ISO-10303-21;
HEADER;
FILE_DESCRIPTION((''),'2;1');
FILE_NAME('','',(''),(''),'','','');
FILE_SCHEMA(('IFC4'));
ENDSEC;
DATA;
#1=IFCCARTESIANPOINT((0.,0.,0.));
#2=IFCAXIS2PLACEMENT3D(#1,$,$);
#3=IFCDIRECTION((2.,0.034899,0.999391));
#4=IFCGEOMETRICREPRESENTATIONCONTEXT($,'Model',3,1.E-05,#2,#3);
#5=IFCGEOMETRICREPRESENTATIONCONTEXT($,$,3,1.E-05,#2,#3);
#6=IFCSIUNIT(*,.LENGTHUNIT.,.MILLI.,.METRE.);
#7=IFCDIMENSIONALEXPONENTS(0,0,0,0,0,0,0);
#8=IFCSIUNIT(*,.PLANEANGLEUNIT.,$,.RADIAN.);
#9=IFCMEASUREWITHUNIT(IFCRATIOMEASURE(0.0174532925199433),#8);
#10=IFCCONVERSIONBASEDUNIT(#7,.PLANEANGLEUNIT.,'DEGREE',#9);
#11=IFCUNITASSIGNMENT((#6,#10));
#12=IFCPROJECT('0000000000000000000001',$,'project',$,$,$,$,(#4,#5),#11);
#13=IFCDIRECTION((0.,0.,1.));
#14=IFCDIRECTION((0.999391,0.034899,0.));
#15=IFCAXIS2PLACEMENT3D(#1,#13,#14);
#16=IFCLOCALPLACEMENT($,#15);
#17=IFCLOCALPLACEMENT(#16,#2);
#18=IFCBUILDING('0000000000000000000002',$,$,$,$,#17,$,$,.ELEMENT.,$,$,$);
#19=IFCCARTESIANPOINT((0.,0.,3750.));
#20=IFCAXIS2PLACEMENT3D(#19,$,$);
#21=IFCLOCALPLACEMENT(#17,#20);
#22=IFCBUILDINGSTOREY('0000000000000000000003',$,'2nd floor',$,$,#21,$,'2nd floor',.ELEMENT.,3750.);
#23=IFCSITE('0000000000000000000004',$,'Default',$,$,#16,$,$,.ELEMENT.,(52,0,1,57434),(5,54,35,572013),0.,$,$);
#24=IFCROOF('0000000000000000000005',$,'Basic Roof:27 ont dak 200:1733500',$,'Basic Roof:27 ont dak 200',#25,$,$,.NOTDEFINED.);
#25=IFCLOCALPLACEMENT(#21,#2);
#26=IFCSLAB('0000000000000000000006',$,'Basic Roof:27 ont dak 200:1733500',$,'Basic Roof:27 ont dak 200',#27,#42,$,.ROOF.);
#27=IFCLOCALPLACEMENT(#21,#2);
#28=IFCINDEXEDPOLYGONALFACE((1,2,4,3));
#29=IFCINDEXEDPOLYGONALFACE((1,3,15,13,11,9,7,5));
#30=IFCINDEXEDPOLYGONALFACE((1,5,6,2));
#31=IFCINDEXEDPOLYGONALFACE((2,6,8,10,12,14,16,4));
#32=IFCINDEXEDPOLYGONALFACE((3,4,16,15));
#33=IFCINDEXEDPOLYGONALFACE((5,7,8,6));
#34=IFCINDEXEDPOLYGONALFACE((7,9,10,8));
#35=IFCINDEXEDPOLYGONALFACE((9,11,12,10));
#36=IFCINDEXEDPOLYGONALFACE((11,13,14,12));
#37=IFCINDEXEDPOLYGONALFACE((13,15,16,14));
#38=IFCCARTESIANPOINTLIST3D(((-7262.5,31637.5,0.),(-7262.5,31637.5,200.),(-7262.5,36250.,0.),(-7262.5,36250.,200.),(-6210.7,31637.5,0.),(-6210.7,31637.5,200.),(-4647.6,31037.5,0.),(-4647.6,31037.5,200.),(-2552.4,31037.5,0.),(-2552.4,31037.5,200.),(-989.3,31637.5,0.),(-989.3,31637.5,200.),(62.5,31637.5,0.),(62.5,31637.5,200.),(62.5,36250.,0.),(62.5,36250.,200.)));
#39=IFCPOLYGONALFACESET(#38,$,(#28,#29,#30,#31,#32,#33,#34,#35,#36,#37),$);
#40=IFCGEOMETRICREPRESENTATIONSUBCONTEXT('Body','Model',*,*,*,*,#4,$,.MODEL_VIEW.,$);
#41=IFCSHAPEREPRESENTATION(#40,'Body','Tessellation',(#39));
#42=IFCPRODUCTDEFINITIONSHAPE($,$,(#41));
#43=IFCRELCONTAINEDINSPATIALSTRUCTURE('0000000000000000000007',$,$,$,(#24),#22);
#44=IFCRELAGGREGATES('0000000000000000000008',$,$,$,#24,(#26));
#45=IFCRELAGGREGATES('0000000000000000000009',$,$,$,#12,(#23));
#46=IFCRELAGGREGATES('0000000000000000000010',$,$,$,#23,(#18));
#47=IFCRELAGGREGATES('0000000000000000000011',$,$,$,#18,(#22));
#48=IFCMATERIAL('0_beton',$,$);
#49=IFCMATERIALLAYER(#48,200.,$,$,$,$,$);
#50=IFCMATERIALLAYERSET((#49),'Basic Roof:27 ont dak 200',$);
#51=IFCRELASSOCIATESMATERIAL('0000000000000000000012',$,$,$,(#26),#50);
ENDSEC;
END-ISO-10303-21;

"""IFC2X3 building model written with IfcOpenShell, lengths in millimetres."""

from ifc_helpers import new_model, entity, si_unit, converted_unit, direction, frame, origin, place, context, subcontext, project, spatial, polyline, outline, extrude, material, layer, layer_set, element, aggregate, save


model = new_model("IFC2X3")

# Units and contexts
model_context = context("Model", 3, precision=1e-05, world=origin(), true_north=direction((2.0, 0.034899, 0.999391)))
context_of_model = context(None, 3, precision=1e-05, world=origin(), true_north=direction((2.0, 0.034899, 0.999391)))
body_context = subcontext(model_context, "Body", "Model", "MODEL_VIEW")
ifc_project = project(units=[si_unit("LENGTHUNIT", "METRE", prefix="MILLI"), converted_unit("PLANEANGLEUNIT", "DEGREE", entity("IfcRatioMeasure", 0.0174532925199433), si_unit("PLANEANGLEUNIT", "RADIAN"), dimensions=[0, 0, 0, 0, 0, 0, 0])], contexts=[model_context, context_of_model])

# Site, building, storey
site_placement = place(None, frame((0.0, 0.0, 0.0), z_axis=(0.0, 0.0, 1.0), x_axis=(0.999391, 0.034899, 0.0)))
site = spatial("IfcSite", under=ifc_project, at=site_placement, Name="Default", CompositionType="ELEMENT", RefLatitude=(52, 0, 1, 57434), RefLongitude=(5, 54, 35, 572013), RefElevation=0.0)
building_placement = place(site_placement, origin())
building = spatial("IfcBuilding", under=site, at=building_placement, CompositionType="ELEMENT")
storey_placement = place(building_placement, frame((0.0, 0.0, 3750.0)))
storey = spatial("IfcBuildingStorey", under=building, at=storey_placement, Name="2nd floor", LongName="2nd floor", CompositionType="ELEMENT", Elevation=3750.0)

# Roof, slab
roof_placement = place(storey_placement, frame((-7262.5, 31037.5, 0.0)))
roof = element("IfcRoof", 1, at=roof_placement, inside=storey, Name="Basic Roof:27 ont dak 200:1733500", ObjectType="Basic Roof:27 ont dak 200", ShapeType="NOTDEFINED")
ifc_material = material(Name="0_beton")
ifc_layer = layer(ifc_material, 200.0)
ifc_layer_set = layer_set([ifc_layer], Name="Basic Roof:27 ont dak 200")
slab_placement = place(roof_placement, origin())
slab = element("IfcSlab", 2, at=slab_placement, material=ifc_layer_set, Name="Basic Roof:27 ont dak 200:1733500", ObjectType="Basic Roof:27 ont dak 200", PredefinedType="ROOF", context=body_context, shape_type="SweptSolid", body=[
    extrude(outline(polyline([(-3662.5, 2606.2), (-3662.5, -2006.2), (-2610.7, -2006.2), (-1047.6, -2606.2), (1047.6, -2606.2), (2610.7, -2006.2), (3662.5, -2006.2), (3662.5, 2606.2), (-3662.5, 2606.2)])), frame((3662.5, 2606.3, 0.0)), (0.0, 0.0, 1.0), 200.0),
])
aggregate(roof, [slab])

save(model, "model.ifc")
